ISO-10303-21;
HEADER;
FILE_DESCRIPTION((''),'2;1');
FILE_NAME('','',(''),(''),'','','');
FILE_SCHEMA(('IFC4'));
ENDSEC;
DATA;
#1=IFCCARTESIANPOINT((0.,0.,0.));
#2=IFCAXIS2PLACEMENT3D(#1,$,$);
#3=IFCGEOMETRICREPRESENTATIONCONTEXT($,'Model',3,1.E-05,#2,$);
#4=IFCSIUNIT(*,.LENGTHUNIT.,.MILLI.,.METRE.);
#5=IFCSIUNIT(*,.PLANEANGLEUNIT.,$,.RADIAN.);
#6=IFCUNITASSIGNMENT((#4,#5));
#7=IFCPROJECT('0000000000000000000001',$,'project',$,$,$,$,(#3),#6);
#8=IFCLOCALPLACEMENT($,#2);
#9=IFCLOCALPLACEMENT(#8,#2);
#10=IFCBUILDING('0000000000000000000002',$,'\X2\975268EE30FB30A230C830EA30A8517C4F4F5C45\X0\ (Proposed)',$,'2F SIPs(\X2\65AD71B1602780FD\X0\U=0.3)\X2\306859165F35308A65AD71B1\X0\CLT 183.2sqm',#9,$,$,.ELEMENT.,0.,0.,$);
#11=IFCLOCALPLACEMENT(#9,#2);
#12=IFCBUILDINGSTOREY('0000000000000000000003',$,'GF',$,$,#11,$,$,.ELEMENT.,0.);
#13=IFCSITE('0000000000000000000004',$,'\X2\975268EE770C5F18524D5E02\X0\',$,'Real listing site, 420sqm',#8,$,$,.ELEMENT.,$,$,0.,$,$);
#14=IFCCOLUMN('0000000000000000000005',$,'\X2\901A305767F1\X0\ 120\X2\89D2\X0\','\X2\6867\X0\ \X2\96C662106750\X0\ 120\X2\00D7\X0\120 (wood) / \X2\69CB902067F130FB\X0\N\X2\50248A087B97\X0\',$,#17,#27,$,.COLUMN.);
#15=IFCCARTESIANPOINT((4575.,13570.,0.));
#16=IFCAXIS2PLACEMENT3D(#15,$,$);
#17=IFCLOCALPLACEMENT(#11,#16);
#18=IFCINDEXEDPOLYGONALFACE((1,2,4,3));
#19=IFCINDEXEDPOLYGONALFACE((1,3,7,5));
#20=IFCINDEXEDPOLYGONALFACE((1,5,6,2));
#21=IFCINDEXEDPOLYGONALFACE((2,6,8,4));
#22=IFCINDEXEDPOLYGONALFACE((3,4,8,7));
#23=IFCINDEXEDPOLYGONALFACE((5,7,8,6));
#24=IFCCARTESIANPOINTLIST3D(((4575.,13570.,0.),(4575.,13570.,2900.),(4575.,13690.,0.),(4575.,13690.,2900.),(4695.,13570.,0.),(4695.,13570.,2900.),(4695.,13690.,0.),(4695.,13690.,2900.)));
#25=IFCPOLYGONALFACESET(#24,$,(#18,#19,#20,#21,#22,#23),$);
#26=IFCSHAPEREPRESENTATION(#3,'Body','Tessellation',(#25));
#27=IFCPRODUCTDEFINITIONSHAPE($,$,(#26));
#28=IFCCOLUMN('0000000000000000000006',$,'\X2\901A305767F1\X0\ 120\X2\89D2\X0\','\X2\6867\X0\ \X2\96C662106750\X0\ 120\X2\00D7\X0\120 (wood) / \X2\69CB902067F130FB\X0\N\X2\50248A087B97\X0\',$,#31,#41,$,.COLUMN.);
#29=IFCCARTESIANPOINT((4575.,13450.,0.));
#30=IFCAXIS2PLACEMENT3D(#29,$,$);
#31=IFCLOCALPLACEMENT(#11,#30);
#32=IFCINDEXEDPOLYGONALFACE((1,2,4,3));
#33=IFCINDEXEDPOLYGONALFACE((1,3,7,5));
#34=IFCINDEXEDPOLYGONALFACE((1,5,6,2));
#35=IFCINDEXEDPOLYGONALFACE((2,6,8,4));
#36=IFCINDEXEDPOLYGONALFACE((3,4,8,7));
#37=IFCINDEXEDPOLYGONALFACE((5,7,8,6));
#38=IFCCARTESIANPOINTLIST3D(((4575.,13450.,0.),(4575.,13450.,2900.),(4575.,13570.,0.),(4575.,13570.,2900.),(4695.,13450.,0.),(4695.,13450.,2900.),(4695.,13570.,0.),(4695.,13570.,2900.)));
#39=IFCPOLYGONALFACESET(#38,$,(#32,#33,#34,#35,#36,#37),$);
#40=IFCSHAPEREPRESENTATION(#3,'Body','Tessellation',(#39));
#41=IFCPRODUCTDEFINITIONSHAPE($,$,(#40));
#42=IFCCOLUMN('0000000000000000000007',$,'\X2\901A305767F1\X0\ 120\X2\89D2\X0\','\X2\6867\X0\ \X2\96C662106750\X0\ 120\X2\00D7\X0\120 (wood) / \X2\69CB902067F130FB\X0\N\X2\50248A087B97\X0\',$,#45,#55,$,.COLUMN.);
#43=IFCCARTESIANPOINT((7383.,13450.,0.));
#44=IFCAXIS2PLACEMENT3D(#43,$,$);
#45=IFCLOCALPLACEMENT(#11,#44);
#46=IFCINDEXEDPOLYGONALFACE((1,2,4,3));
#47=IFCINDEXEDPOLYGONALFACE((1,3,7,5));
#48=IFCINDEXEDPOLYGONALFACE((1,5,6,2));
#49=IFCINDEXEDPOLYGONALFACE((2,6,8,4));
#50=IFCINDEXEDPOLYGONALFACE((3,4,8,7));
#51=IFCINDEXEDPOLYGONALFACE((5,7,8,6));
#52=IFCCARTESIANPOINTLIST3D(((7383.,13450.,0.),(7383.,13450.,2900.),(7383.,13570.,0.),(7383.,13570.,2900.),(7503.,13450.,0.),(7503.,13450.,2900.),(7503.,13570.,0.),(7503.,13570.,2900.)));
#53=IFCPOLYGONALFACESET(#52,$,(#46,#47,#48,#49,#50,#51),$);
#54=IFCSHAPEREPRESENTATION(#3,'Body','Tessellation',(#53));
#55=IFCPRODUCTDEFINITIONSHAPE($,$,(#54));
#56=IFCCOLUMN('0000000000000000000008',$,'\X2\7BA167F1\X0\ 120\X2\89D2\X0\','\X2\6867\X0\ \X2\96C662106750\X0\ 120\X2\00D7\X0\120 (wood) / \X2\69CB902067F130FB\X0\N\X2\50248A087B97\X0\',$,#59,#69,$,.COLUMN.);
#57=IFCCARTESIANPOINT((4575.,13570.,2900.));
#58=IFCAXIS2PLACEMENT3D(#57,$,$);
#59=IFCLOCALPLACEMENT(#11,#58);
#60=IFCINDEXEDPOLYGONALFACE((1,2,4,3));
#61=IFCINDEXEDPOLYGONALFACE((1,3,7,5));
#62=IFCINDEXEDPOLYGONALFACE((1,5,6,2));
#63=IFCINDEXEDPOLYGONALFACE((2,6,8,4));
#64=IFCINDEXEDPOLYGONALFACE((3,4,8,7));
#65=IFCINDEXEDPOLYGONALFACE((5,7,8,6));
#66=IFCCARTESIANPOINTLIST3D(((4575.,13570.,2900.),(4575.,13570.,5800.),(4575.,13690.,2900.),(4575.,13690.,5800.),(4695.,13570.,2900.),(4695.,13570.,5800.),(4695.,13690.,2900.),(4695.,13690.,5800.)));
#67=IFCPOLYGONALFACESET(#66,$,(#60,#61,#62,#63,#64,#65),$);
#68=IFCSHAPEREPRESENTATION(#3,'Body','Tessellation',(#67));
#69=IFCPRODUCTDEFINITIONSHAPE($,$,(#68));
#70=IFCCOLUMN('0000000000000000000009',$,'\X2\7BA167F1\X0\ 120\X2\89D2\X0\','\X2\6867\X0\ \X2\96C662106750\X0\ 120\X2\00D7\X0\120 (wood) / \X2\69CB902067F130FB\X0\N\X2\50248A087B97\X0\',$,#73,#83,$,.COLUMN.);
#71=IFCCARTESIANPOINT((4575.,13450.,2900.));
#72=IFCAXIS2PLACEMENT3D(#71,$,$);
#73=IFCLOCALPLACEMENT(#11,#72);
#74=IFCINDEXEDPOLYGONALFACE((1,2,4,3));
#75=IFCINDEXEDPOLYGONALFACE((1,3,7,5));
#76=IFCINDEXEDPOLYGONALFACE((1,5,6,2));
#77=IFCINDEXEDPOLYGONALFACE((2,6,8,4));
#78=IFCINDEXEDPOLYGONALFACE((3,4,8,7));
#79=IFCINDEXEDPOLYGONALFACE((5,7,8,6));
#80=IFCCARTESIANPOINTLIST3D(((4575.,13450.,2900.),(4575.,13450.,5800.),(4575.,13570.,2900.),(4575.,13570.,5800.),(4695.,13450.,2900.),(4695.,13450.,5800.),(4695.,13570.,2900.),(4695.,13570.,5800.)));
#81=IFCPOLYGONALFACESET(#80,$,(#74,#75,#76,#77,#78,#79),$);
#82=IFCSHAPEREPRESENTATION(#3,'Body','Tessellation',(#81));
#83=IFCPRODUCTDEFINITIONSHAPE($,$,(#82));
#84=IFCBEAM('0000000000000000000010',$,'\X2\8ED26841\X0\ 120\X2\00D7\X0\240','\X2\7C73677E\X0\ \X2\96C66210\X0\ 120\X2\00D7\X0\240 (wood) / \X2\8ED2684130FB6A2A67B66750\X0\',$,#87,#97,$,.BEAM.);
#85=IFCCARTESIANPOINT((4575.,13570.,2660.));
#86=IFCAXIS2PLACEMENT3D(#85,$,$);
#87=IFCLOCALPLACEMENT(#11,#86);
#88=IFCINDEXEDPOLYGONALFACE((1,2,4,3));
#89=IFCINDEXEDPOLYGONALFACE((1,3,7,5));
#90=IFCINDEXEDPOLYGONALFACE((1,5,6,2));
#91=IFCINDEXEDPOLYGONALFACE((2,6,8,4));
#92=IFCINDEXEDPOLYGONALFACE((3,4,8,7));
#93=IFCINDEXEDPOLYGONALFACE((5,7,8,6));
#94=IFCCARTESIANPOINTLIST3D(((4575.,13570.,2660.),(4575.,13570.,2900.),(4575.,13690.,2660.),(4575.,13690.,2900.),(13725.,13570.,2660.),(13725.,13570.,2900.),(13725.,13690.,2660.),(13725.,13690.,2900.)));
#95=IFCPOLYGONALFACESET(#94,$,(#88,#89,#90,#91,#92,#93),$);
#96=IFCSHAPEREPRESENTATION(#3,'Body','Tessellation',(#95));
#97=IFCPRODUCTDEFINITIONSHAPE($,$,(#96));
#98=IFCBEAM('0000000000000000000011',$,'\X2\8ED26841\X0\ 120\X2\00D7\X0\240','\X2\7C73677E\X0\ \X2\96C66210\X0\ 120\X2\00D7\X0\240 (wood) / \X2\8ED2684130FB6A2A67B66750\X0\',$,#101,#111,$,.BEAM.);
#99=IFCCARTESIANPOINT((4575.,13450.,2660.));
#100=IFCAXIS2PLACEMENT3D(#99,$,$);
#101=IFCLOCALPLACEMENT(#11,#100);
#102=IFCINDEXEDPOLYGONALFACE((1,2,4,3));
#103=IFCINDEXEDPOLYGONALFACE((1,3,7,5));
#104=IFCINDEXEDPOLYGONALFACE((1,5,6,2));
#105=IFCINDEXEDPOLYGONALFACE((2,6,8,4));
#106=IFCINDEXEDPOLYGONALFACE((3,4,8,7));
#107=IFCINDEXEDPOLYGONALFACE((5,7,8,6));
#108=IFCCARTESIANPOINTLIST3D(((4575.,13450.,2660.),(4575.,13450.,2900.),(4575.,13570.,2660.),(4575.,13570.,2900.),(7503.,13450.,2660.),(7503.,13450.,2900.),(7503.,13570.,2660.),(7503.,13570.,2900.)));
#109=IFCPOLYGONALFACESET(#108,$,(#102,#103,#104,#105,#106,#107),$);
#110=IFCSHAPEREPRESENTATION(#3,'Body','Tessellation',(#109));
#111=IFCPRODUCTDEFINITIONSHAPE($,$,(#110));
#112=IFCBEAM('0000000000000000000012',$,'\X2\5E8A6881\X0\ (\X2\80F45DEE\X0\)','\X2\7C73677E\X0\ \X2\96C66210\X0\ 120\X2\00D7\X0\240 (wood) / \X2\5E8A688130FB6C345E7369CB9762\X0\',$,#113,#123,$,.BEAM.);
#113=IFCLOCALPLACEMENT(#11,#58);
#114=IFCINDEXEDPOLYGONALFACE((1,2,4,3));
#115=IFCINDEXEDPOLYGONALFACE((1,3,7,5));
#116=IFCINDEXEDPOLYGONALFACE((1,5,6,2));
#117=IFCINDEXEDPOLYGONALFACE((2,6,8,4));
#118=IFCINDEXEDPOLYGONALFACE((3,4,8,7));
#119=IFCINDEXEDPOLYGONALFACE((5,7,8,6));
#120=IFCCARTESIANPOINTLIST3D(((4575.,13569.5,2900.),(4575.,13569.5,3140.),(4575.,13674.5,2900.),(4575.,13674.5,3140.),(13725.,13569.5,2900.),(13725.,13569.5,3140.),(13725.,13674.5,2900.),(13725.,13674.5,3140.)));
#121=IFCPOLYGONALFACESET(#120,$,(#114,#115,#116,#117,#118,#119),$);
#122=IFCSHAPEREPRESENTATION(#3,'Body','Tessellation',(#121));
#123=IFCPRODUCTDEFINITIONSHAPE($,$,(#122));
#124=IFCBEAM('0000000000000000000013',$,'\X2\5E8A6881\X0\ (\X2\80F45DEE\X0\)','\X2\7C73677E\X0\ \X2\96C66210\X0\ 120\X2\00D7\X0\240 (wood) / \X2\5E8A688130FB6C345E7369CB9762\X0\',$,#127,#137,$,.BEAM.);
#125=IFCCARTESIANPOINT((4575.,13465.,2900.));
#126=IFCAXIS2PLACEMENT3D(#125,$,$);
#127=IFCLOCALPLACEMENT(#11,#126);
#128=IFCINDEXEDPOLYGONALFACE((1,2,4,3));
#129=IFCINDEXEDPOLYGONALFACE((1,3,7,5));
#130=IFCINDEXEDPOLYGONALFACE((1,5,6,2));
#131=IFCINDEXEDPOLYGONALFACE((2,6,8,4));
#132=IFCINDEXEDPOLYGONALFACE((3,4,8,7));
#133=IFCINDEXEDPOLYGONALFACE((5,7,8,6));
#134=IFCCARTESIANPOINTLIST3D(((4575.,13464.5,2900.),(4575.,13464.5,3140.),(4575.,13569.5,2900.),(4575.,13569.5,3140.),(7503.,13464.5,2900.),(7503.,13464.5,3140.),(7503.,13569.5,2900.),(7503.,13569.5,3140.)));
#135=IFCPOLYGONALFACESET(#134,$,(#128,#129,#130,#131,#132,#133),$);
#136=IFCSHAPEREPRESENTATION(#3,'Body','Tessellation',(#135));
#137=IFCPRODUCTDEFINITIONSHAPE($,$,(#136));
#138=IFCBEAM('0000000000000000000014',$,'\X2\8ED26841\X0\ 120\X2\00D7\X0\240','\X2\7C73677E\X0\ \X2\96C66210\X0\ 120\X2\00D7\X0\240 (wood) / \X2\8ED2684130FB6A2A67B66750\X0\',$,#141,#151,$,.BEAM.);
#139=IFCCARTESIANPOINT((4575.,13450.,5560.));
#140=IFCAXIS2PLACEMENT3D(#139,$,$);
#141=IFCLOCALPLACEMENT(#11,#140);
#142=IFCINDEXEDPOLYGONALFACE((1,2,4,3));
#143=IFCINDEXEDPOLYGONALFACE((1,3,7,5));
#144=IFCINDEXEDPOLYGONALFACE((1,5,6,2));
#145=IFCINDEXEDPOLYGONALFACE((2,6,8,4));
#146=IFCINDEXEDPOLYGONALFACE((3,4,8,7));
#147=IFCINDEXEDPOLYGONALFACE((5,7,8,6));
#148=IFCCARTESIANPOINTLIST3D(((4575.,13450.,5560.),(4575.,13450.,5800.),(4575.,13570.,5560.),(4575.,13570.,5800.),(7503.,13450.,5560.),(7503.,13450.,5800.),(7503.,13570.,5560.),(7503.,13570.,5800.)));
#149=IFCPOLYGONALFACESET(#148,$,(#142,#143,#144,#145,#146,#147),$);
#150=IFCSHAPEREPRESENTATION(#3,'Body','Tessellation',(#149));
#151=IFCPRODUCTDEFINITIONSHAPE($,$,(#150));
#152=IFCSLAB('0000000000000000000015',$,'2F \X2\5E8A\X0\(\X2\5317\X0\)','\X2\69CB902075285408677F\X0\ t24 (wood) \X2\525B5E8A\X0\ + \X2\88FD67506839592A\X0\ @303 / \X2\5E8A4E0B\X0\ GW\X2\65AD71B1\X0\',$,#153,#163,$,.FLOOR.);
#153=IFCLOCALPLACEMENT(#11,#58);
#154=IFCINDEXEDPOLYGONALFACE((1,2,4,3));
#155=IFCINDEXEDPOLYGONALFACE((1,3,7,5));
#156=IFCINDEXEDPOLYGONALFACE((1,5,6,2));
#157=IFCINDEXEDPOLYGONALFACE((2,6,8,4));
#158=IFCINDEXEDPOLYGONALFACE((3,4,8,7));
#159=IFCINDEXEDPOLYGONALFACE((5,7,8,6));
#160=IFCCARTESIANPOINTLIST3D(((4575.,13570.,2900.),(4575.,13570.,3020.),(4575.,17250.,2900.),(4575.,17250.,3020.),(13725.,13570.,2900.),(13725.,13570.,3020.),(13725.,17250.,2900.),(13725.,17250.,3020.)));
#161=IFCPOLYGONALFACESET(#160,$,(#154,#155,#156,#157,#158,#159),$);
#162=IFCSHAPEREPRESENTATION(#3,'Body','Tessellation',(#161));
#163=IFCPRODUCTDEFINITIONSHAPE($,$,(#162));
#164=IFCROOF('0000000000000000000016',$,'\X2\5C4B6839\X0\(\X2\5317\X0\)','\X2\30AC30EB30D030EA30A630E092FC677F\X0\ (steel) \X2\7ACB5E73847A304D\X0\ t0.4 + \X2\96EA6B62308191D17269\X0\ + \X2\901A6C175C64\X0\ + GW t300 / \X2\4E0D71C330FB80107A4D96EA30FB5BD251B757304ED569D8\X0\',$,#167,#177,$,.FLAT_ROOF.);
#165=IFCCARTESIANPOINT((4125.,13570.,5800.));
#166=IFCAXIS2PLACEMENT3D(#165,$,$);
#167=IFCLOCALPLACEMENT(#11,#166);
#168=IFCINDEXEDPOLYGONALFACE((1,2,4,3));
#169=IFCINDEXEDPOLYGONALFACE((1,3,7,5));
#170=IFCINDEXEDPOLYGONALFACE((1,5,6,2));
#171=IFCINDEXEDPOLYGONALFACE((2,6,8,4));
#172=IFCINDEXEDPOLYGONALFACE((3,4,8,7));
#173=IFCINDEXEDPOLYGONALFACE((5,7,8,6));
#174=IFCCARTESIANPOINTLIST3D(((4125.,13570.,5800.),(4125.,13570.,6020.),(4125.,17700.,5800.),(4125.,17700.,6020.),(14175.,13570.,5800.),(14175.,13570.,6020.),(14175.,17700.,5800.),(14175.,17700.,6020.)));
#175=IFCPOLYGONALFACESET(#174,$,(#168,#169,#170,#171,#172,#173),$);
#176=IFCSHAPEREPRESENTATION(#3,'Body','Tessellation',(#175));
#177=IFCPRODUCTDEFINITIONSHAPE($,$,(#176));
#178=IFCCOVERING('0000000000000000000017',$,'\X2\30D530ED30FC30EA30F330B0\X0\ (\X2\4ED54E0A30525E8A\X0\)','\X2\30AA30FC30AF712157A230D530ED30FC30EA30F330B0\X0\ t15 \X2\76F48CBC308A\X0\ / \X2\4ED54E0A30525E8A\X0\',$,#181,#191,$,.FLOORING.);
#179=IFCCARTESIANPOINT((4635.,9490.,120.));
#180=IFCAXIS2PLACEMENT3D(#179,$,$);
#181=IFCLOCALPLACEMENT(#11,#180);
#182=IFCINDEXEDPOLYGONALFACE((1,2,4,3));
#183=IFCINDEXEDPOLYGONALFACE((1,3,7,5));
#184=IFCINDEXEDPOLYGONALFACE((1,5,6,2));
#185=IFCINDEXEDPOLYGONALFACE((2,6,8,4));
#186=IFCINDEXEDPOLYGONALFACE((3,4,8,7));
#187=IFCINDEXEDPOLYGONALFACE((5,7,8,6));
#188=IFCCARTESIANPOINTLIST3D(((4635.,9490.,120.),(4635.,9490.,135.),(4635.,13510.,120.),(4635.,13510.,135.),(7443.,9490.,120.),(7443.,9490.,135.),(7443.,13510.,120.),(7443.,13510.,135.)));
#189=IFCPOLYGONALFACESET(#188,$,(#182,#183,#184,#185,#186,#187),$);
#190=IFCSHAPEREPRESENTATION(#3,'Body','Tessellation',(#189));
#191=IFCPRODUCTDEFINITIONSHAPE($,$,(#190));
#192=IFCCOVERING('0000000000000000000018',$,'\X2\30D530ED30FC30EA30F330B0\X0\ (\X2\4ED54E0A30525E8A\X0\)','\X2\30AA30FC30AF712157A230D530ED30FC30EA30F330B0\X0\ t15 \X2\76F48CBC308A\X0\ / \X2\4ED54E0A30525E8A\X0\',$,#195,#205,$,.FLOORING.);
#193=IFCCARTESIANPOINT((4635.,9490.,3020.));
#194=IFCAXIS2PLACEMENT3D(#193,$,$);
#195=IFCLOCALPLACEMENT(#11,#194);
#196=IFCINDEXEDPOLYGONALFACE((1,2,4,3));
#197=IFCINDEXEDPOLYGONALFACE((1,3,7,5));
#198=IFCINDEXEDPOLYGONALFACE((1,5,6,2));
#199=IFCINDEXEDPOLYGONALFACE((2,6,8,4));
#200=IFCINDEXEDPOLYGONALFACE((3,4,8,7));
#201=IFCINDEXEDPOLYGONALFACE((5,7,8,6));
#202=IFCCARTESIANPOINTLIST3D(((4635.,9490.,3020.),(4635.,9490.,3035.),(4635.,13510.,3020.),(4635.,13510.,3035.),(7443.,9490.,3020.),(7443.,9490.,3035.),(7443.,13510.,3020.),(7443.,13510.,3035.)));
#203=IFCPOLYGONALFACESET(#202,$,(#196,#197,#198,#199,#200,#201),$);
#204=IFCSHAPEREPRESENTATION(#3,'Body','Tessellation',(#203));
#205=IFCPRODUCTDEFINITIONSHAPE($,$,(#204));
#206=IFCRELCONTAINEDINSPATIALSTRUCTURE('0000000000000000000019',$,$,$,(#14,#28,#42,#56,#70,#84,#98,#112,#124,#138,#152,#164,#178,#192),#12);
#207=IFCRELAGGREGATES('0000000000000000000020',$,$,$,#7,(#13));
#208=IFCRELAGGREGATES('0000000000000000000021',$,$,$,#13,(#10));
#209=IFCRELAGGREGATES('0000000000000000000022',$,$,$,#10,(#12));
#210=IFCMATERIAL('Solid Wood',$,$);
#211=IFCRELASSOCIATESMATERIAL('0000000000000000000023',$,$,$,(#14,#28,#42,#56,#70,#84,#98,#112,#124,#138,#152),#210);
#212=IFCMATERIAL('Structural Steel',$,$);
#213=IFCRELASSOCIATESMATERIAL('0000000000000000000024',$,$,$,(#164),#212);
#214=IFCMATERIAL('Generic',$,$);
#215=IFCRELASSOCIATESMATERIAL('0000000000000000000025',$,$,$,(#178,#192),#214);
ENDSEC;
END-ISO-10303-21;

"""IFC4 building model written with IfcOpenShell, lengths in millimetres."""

from ifc_helpers import new_model, si_unit, frame, frame_2d, origin, place, context, project, spatial, rectangle, extrude, material, element, save


model = new_model("IFC4")

# Units and contexts
model_context = context("Model", 3, precision=1e-05, world=origin())
ifc_project = project(units=[si_unit("LENGTHUNIT", "METRE", prefix="MILLI"), si_unit("PLANEANGLEUNIT", "RADIAN")], contexts=[model_context])

# Site, building, storey
site_placement = place(None, origin())
site = spatial("IfcSite", under=ifc_project, at=site_placement, Name="青森県弘前市", ObjectType="Real listing site, 420sqm", CompositionType="ELEMENT", RefElevation=0.0)
building_placement = place(site_placement, origin())
building = spatial("IfcBuilding", under=site, at=building_placement, Name="青森・アトリエ兼住居 (Proposed)", ObjectType="2F SIPs(断熱性能U=0.3)と外張り断熱CLT 183.2sqm", CompositionType="ELEMENT", ElevationOfRefHeight=0.0, ElevationOfTerrain=0.0)
storey_placement = place(building_placement, origin())
storey = spatial("IfcBuildingStorey", under=building, at=storey_placement, Name="GF", CompositionType="ELEMENT", Elevation=0.0)

# Columns
ifc_material_1 = material(Name="Solid Wood")
column_1_placement = place(storey_placement, frame((4575.0, 13570.0, 0.0)))
element("IfcColumn", 1, at=column_1_placement, inside=storey, material=ifc_material_1, Name="通し柱 120角", Description="桧 集成材 120×120 (wood) / 構造柱・N値計算", PredefinedType="COLUMN", context=model_context, shape_type="SweptSolid", body=[
    extrude(rectangle(XDim=120.0, YDim=120.0, at=frame_2d((60.0, 60.0))), frame((4575.0, 13570.0, 0.0)), (0.0, 0.0, 1.0), 2900.0),
])
column_2_placement = place(storey_placement, frame((4575.0, 13450.0, 0.0)))
element("IfcColumn", 2, at=column_2_placement, inside=storey, material=ifc_material_1, Name="通し柱 120角", Description="桧 集成材 120×120 (wood) / 構造柱・N値計算", PredefinedType="COLUMN", context=model_context, shape_type="SweptSolid", body=[
    extrude(rectangle(XDim=120.0, YDim=120.0, at=frame_2d((60.0, 60.0))), frame((4575.0, 13450.0, 0.0)), (0.0, 0.0, 1.0), 2900.0),
])
column_3_placement = place(storey_placement, frame((7383.0, 13450.0, 0.0)))
element("IfcColumn", 3, at=column_3_placement, inside=storey, material=ifc_material_1, Name="通し柱 120角", Description="桧 集成材 120×120 (wood) / 構造柱・N値計算", PredefinedType="COLUMN", context=model_context, shape_type="SweptSolid", body=[
    extrude(rectangle(XDim=120.0, YDim=120.0, at=frame_2d((60.0, 60.0))), frame((7383.0, 13450.0, 0.0)), (0.0, 0.0, 1.0), 2900.0),
])
column_4_placement = place(storey_placement, frame((4575.0, 13570.0, 2900.0)))
element("IfcColumn", 4, at=column_4_placement, inside=storey, material=ifc_material_1, Name="管柱 120角", Description="桧 集成材 120×120 (wood) / 構造柱・N値計算", PredefinedType="COLUMN", context=model_context, shape_type="SweptSolid", body=[
    extrude(rectangle(XDim=120.0, YDim=120.0, at=frame_2d((60.0, 60.0))), frame((4575.0, 13570.0, 2900.0)), (0.0, 0.0, 1.0), 2900.0),
])
column_5_placement = place(storey_placement, frame((4575.0, 13450.0, 2900.0)))
element("IfcColumn", 5, at=column_5_placement, inside=storey, material=ifc_material_1, Name="管柱 120角", Description="桧 集成材 120×120 (wood) / 構造柱・N値計算", PredefinedType="COLUMN", context=model_context, shape_type="SweptSolid", body=[
    extrude(rectangle(XDim=120.0, YDim=120.0, at=frame_2d((60.0, 60.0))), frame((4575.0, 13450.0, 2900.0)), (0.0, 0.0, 1.0), 2900.0),
])

# Beams
beam_1_placement = place(storey_placement, frame((4575.0, 13570.0, 2660.0)))
element("IfcBeam", 6, at=beam_1_placement, inside=storey, material=ifc_material_1, Name="軒桁 120×240", Description="米松 集成 120×240 (wood) / 軒桁・横架材", PredefinedType="BEAM", context=model_context, shape_type="SweptSolid", body=[
    extrude(rectangle(XDim=9150.0, YDim=120.0, at=frame_2d((4575.0, 60.0))), frame((4575.0, 13570.0, 2660.0)), (0.0, 0.0, 1.0), 240.0),
])
beam_2_placement = place(storey_placement, frame((4575.0, 13450.0, 2660.0)))
element("IfcBeam", 7, at=beam_2_placement, inside=storey, material=ifc_material_1, Name="軒桁 120×240", Description="米松 集成 120×240 (wood) / 軒桁・横架材", PredefinedType="BEAM", context=model_context, shape_type="SweptSolid", body=[
    extrude(rectangle(XDim=2928.0, YDim=120.0, at=frame_2d((1464.0, 60.0))), frame((4575.0, 13450.0, 2660.0)), (0.0, 0.0, 1.0), 240.0),
])
beam_3_placement = place(storey_placement, frame((4575.0, 13570.0, 2900.0)))
element("IfcBeam", 8, at=beam_3_placement, inside=storey, material=ifc_material_1, Name="床梁 (胴差)", Description="米松 集成 120×240 (wood) / 床梁・水平構面", PredefinedType="BEAM", context=model_context, shape_type="SweptSolid", body=[
    extrude(rectangle(XDim=9150.0, YDim=105.0, at=frame_2d((4575.0, 52.0))), frame((4575.0, 13570.0, 2900.0)), (0.0, 0.0, 1.0), 240.0),
])
beam_4_placement = place(storey_placement, frame((4575.0, 13465.0, 2900.0)))
element("IfcBeam", 9, at=beam_4_placement, inside=storey, material=ifc_material_1, Name="床梁 (胴差)", Description="米松 集成 120×240 (wood) / 床梁・水平構面", PredefinedType="BEAM", context=model_context, shape_type="SweptSolid", body=[
    extrude(rectangle(XDim=2928.0, YDim=105.0, at=frame_2d((1464.0, 52.0))), frame((4575.0, 13465.0, 2900.0)), (0.0, 0.0, 1.0), 240.0),
])
beam_5_placement = place(storey_placement, frame((4575.0, 13450.0, 5560.0)))
element("IfcBeam", 10, at=beam_5_placement, inside=storey, material=ifc_material_1, Name="軒桁 120×240", Description="米松 集成 120×240 (wood) / 軒桁・横架材", PredefinedType="BEAM", context=model_context, shape_type="SweptSolid", body=[
    extrude(rectangle(XDim=2928.0, YDim=120.0, at=frame_2d((1464.0, 60.0))), frame((4575.0, 13450.0, 5560.0)), (0.0, 0.0, 1.0), 240.0),
])

# Slab
slab_1_placement = place(storey_placement, frame((4575.0, 13570.0, 2900.0)))
element("IfcSlab", 11, at=slab_1_placement, inside=storey, material=ifc_material_1, Name="2F 床(北)", Description="構造用合板 t24 (wood) 剛床 + 製材根太 @303 / 床下 GW断熱", PredefinedType="FLOOR", context=model_context, shape_type="SweptSolid", body=[
    extrude(rectangle(XDim=9150.0, YDim=3680.0, at=frame_2d((4575.0, 1840.0))), frame((4575.0, 13570.0, 2900.0)), (0.0, 0.0, 1.0), 120.0),
])

# Roof
ifc_material_2 = material(Name="Structural Steel")
for number, where, name in (
    (12, (4125.0, 13570.0, 5800.0), "屋根(北)"),
):
    element("IfcRoof", number, at=place(storey_placement, frame(where)), inside=storey, material=ifc_material_2, Name=name, Description="ガルバリウム鋼板 (steel) 立平葺き t0.4 + 雪止め金物 + 通気層 + GW t300 / 不燃・耐積雪・寒冷地仕様", PredefinedType="FLAT_ROOF", context=model_context, shape_type="SweptSolid", body=[
        extrude(rectangle(XDim=10050.0, YDim=4130.0, at=frame_2d((5025.0, 2065.0))), frame((4125.0, 13570.0, 5800.0)), (0.0, 0.0, 1.0), 220.0),
    ])

# Coverings
ifc_material_3 = material(Name="Generic")
covering_1_placement = place(storey_placement, frame((4635.0, 9490.0, 120.0)))
element("IfcCovering", 13, at=covering_1_placement, inside=storey, material=ifc_material_3, Name="フローリング (仕上げ床)", Description="オーク無垢フローリング t15 直貼り / 仕上げ床", PredefinedType="FLOORING", context=model_context, shape_type="SweptSolid", body=[
    extrude(rectangle(XDim=2808.0, YDim=4020.0, at=frame_2d((1404.0, 2010.0))), frame((4635.0, 9490.0, 120.0)), (0.0, 0.0, 1.0), 15.0),
])
covering_2_placement = place(storey_placement, frame((4635.0, 9490.0, 3020.0)))
element("IfcCovering", 14, at=covering_2_placement, inside=storey, material=ifc_material_3, Name="フローリング (仕上げ床)", Description="オーク無垢フローリング t15 直貼り / 仕上げ床", PredefinedType="FLOORING", context=model_context, shape_type="SweptSolid", body=[
    extrude(rectangle(XDim=2808.0, YDim=4020.0, at=frame_2d((1404.0, 2010.0))), frame((4635.0, 9490.0, 3020.0)), (0.0, 0.0, 1.0), 15.0),
])

save(model, "model.ifc")
